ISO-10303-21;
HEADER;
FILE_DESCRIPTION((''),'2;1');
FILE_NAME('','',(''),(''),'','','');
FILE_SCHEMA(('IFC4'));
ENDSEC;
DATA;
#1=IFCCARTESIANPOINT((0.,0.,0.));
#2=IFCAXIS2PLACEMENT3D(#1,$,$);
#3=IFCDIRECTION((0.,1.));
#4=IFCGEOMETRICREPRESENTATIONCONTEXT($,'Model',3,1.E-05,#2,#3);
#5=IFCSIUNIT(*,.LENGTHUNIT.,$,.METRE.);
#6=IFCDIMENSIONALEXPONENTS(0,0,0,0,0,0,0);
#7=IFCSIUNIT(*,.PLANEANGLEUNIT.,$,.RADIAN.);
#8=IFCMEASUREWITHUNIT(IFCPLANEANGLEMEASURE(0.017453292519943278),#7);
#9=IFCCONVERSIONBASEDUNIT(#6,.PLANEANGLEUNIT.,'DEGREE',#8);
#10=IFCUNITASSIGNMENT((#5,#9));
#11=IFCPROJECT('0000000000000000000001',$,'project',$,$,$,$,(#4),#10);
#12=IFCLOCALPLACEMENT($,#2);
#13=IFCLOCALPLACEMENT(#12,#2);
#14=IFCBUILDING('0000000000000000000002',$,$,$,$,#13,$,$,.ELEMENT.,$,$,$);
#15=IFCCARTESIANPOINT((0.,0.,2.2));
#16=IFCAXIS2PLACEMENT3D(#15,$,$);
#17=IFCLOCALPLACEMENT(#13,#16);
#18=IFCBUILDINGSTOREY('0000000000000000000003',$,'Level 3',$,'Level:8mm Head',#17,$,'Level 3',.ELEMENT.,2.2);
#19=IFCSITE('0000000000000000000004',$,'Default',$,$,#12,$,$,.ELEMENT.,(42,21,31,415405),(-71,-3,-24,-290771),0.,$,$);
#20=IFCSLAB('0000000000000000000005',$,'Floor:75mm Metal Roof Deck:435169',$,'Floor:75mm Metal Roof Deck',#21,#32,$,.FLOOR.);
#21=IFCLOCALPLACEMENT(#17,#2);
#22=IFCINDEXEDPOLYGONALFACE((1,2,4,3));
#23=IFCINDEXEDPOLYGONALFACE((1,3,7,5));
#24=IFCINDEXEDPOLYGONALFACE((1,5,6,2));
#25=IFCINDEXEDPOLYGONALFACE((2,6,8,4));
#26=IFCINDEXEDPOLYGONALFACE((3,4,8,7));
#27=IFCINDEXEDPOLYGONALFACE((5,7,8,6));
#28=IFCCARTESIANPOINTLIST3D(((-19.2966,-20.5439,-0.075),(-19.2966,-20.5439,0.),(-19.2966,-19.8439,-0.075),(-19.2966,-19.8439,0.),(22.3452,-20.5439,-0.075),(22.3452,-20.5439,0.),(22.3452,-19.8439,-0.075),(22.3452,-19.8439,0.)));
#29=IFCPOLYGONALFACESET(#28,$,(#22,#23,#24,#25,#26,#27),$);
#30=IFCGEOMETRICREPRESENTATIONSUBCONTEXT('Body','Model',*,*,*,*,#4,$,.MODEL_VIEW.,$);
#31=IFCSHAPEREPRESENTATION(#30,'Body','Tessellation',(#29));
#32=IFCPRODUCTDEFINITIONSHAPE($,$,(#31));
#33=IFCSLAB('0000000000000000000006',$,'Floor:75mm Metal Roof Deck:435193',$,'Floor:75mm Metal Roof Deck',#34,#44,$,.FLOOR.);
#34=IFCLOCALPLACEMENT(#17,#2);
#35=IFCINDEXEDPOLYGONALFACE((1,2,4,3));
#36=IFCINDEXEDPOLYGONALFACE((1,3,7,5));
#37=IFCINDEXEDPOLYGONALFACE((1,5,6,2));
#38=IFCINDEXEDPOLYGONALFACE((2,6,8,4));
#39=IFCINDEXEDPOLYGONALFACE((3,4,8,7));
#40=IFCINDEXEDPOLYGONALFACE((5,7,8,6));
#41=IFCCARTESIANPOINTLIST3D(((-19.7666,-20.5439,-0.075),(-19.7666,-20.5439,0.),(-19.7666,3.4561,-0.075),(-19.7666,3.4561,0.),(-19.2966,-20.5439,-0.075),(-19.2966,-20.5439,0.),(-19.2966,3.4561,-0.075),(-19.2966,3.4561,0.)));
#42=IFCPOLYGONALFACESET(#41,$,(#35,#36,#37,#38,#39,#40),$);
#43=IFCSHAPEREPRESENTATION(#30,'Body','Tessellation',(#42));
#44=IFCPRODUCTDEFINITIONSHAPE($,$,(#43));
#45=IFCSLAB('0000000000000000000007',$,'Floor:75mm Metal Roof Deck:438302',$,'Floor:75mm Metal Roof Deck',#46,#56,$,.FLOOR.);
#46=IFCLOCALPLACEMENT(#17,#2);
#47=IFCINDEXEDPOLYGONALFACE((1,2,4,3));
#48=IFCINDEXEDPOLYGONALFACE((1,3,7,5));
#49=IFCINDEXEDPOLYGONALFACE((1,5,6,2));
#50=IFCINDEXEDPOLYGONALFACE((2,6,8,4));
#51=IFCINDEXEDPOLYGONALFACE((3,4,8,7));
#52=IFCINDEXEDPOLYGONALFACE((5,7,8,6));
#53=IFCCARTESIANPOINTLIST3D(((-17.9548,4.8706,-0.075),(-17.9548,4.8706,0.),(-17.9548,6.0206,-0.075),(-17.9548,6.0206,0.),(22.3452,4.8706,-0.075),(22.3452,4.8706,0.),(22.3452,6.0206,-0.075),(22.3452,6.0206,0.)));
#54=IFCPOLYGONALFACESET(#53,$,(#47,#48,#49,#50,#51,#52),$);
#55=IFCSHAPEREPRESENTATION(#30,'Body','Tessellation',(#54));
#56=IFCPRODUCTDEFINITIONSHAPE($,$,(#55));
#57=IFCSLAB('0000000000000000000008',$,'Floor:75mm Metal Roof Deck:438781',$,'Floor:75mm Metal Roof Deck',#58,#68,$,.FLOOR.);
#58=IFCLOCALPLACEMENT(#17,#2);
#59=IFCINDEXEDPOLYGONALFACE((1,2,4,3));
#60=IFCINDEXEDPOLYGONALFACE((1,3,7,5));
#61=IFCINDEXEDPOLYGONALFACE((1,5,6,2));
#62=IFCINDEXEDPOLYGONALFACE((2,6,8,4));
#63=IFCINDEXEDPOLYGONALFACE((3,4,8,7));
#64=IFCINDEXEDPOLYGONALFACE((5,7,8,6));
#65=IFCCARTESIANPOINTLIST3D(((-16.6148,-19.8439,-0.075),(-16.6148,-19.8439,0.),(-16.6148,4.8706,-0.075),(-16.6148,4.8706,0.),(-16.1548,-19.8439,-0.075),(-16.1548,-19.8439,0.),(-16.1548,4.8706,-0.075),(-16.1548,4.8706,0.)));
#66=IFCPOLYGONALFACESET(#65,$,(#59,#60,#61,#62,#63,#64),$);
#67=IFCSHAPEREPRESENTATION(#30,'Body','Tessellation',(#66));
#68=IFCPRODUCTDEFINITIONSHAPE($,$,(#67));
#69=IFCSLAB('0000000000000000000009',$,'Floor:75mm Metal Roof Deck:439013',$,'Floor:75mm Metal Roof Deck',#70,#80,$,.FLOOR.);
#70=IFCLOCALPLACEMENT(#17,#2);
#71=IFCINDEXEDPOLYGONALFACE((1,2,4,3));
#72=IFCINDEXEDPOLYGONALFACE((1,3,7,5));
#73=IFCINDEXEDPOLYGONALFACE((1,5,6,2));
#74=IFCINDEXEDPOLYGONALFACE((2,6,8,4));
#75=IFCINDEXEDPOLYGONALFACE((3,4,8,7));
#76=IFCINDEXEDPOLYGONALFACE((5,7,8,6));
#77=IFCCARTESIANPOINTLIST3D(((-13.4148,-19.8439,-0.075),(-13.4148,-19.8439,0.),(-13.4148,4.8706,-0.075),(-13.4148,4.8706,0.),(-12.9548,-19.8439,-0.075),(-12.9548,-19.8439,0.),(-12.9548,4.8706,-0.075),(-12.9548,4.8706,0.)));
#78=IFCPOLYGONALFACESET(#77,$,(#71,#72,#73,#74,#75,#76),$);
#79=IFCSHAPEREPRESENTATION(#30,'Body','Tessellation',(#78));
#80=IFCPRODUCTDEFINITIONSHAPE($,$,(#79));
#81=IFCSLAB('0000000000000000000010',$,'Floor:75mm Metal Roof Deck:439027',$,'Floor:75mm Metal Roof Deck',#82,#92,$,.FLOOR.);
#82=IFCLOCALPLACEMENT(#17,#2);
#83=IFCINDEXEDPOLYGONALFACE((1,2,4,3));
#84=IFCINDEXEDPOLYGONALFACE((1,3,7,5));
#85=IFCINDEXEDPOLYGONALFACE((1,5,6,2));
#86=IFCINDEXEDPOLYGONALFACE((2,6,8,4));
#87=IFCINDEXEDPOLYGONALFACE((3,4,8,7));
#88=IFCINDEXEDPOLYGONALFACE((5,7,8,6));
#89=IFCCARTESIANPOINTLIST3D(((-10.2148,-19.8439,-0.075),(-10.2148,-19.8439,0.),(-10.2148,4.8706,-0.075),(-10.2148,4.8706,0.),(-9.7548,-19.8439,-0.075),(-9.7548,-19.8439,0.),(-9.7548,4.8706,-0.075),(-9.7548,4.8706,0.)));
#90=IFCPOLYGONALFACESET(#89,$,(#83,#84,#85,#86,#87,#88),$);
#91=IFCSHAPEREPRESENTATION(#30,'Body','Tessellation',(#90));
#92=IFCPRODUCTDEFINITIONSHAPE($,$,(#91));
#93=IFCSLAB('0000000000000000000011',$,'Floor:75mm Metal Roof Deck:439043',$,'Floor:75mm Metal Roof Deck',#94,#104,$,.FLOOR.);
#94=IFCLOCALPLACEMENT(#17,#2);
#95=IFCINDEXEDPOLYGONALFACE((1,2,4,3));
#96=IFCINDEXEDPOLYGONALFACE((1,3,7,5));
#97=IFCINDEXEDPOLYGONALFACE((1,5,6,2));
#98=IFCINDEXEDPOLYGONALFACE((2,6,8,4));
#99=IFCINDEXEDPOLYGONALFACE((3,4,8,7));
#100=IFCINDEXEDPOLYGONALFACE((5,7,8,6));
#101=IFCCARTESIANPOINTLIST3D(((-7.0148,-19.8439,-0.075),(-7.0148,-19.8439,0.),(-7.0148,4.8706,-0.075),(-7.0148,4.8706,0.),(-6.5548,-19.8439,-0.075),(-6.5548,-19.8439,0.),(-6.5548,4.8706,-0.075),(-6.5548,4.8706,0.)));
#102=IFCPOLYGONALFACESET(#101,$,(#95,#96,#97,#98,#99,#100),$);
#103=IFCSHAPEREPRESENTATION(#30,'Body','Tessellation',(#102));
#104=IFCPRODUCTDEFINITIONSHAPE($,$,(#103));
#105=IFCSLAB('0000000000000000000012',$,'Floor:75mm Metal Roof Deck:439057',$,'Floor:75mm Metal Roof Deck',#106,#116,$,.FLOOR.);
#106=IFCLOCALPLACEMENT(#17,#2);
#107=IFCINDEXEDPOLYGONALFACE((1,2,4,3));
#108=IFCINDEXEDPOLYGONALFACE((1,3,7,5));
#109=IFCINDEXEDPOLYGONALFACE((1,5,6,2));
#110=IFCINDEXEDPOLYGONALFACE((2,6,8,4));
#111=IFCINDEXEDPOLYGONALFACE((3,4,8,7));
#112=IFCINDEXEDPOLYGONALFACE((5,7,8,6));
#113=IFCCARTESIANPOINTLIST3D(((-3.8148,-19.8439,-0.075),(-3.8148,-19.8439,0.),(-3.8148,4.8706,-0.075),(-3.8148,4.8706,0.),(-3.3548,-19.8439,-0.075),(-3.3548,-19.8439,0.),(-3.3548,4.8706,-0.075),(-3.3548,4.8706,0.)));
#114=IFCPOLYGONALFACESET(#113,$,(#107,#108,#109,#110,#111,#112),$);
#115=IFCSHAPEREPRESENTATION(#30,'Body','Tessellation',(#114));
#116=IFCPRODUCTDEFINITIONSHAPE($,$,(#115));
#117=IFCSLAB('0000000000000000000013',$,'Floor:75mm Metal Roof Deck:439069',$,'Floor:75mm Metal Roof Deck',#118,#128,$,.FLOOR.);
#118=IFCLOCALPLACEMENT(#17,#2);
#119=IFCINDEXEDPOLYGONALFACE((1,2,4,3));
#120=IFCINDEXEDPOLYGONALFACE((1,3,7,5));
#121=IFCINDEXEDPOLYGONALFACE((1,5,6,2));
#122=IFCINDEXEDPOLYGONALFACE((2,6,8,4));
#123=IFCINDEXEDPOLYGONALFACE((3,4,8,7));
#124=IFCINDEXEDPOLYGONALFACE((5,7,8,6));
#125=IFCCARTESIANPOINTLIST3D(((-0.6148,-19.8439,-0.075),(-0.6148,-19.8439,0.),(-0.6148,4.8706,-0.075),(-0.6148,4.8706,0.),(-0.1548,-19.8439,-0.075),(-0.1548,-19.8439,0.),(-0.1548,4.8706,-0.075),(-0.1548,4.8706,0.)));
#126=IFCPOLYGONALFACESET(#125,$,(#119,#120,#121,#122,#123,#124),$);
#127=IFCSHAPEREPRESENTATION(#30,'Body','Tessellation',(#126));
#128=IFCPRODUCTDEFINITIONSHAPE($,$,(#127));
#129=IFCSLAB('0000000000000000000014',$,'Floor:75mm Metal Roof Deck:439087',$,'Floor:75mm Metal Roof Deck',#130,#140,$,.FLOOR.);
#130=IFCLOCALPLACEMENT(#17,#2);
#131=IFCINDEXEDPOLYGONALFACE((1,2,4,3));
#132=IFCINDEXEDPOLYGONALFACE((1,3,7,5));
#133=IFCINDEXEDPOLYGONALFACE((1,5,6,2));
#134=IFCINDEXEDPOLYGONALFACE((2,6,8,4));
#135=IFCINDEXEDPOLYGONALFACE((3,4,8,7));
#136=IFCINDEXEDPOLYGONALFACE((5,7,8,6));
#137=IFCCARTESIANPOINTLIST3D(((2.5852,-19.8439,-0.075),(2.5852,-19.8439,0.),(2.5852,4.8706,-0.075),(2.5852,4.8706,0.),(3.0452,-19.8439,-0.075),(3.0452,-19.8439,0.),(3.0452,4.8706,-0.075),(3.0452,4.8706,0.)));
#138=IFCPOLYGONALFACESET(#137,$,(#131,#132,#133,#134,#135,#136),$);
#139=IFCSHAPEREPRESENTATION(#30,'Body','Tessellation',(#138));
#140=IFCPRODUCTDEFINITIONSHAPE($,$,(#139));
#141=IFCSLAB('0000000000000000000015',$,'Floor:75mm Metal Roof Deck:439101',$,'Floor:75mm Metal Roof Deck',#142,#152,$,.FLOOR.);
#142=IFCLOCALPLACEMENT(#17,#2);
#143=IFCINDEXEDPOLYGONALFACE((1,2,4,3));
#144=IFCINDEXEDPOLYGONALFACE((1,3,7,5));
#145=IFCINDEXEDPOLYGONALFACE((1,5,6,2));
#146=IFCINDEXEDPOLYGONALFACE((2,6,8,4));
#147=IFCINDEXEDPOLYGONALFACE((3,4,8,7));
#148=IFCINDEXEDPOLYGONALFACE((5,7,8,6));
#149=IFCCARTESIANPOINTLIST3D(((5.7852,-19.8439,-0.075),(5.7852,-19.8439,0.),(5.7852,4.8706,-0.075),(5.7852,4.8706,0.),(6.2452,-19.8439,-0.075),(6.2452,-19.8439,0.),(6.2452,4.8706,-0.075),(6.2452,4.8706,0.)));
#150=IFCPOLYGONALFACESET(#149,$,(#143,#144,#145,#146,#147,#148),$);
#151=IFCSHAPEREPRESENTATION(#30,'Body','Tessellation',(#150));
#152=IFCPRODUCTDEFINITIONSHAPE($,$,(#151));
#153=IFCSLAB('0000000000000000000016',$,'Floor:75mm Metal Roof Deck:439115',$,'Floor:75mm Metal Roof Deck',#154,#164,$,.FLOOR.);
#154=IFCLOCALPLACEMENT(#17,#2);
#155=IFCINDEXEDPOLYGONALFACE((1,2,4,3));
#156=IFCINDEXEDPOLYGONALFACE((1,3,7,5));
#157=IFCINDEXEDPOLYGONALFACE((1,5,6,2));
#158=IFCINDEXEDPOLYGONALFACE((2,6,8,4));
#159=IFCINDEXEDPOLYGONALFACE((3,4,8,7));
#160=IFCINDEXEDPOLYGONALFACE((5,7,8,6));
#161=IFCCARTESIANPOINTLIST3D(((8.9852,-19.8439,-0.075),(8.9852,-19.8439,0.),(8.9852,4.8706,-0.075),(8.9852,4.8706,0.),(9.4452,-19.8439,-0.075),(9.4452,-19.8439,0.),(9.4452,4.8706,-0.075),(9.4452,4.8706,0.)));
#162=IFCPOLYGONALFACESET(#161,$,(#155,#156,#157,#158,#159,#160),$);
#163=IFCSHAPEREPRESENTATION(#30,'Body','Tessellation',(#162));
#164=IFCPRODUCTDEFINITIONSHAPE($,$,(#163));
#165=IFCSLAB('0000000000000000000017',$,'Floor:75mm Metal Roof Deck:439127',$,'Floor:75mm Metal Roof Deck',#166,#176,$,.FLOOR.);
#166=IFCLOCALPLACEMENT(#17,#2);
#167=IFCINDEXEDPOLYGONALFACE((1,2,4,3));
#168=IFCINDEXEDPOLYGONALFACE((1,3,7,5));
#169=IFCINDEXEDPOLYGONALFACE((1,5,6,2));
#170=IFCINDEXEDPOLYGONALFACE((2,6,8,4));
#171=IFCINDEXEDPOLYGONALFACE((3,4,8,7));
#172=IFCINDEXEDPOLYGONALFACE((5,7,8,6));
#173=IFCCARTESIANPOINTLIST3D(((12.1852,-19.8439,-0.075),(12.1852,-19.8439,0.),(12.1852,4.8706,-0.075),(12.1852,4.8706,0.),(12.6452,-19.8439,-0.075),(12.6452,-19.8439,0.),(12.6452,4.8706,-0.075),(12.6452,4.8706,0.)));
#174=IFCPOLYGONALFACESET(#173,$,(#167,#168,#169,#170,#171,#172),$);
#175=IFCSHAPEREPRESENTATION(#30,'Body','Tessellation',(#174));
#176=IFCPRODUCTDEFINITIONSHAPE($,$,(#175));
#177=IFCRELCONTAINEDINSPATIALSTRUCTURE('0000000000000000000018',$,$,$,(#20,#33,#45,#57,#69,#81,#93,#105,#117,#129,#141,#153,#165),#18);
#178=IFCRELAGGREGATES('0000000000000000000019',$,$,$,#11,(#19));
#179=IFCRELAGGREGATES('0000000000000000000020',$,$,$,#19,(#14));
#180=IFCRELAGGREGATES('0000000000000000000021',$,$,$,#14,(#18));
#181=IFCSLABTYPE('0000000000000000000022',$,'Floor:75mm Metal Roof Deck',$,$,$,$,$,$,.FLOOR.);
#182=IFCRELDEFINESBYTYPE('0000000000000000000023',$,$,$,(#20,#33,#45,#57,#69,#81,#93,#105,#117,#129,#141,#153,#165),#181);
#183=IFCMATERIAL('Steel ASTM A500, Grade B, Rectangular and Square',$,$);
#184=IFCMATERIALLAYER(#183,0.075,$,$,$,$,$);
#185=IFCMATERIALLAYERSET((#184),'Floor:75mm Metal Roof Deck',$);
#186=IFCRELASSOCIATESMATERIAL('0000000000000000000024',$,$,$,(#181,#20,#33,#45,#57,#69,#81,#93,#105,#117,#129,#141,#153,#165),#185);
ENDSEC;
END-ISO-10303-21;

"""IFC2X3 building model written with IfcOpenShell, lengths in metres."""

from ifc_helpers import new_model, entity, si_unit, converted_unit, direction, frame, frame_2d, origin, place, context, subcontext, project, spatial, rectangle, extrude, material, layer, layer_set, layer_usage, type_object, element, save


model = new_model("IFC2X3")

# Units and contexts
model_context = context("Model", 3, precision=1e-05, world=origin(), true_north=direction((0.0, 1.0)))
body_context = subcontext(model_context, "Body", "Model", "MODEL_VIEW")
ifc_project = project(units=[si_unit("LENGTHUNIT", "METRE"), converted_unit("PLANEANGLEUNIT", "DEGREE", entity("IfcPlaneAngleMeasure", 0.017453292519943278), si_unit("PLANEANGLEUNIT", "RADIAN"), dimensions=[0, 0, 0, 0, 0, 0, 0])], contexts=[model_context])

# Site, building, storey
site_placement = place(None, origin())
site = spatial("IfcSite", under=ifc_project, at=site_placement, Name="Default", CompositionType="ELEMENT", RefLatitude=(42, 21, 31, 415405), RefLongitude=(-71, -3, -24, -290771), RefElevation=0.0)
building_placement = place(site_placement, origin())
building = spatial("IfcBuilding", under=site, at=building_placement, CompositionType="ELEMENT")
storey_placement = place(building_placement, frame((0.0, 0.0, 2.2)))
storey = spatial("IfcBuildingStorey", under=building, at=storey_placement, Name="Level 3", ObjectType="Level:8mm Head", LongName="Level 3", CompositionType="ELEMENT", Elevation=2.2)

# Slabs
ifc_material = material(Name="Steel ASTM A500, Grade B, Rectangular and Square")
ifc_layer = layer(ifc_material, 0.075)
ifc_layer_set = layer_set([ifc_layer], Name="Floor:75mm Metal Roof Deck")
ifc_layer_usage_1 = layer_usage(ifc_layer_set, "AXIS3", "POSITIVE", 0.0)
slab_type = type_object("IfcSlabType", Name="Floor:75mm Metal Roof Deck", PredefinedType="FLOOR", material=ifc_layer_set)
slab_1_placement = place(storey_placement, origin())
element("IfcSlab", 1, at=slab_1_placement, inside=storey, type_object=slab_type, material=ifc_layer_usage_1, Name="Floor:75mm Metal Roof Deck:435169", ObjectType="Floor:75mm Metal Roof Deck", PredefinedType="FLOOR", context=body_context, shape_type="SweptSolid", body=[
    extrude(rectangle(XDim=0.7, YDim=41.6417, at=frame_2d((0.0, 0.0), x_axis=(1.0, 0.0))), frame((1.5243, -20.1939, 0.0), z_axis=(0.0, 0.0, -1.0), x_axis=(0.0, 1.0, 0.0)), (0.0, 0.0, 1.0), 0.075),
])
ifc_layer_usage_2 = layer_usage(ifc_layer_set, "AXIS3", "POSITIVE", 0.0)
slab_2_placement = place(storey_placement, origin())
element("IfcSlab", 2, at=slab_2_placement, inside=storey, type_object=slab_type, material=ifc_layer_usage_2, Name="Floor:75mm Metal Roof Deck:435193", ObjectType="Floor:75mm Metal Roof Deck", PredefinedType="FLOOR", context=body_context, shape_type="SweptSolid", body=[
    extrude(rectangle(XDim=24.0, YDim=0.47, at=frame_2d((0.0, 0.0), x_axis=(1.0, 0.0))), frame((-19.5316, -8.5439, 0.0), z_axis=(0.0, 0.0, -1.0), x_axis=(0.0, 1.0, 0.0)), (0.0, 0.0, 1.0), 0.075),
])
ifc_layer_usage_3 = layer_usage(ifc_layer_set, "AXIS3", "POSITIVE", 0.0)
slab_3_placement = place(storey_placement, origin())
element("IfcSlab", 3, at=slab_3_placement, inside=storey, type_object=slab_type, material=ifc_layer_usage_3, Name="Floor:75mm Metal Roof Deck:438302", ObjectType="Floor:75mm Metal Roof Deck", PredefinedType="FLOOR", context=body_context, shape_type="SweptSolid", body=[
    extrude(rectangle(XDim=1.15, YDim=40.3, at=frame_2d((0.0, 0.0), x_axis=(1.0, 0.0))), frame((2.1952, 5.4456, 0.0), z_axis=(0.0, 0.0, -1.0), x_axis=(0.0, 1.0, 0.0)), (0.0, 0.0, 1.0), 0.075),
])
ifc_layer_usage_4 = layer_usage(ifc_layer_set, "AXIS3", "POSITIVE", 0.0)
slab_4_placement = place(storey_placement, origin())
element("IfcSlab", 4, at=slab_4_placement, inside=storey, type_object=slab_type, material=ifc_layer_usage_4, Name="Floor:75mm Metal Roof Deck:438781", ObjectType="Floor:75mm Metal Roof Deck", PredefinedType="FLOOR", context=body_context, shape_type="SweptSolid", body=[
    extrude(rectangle(XDim=24.7144, YDim=0.46, at=frame_2d((0.0, 0.0), x_axis=(1.0, 0.0))), frame((-16.3848, -7.4867, 0.0), z_axis=(0.0, 0.0, -1.0), x_axis=(0.0, 1.0, 0.0)), (0.0, 0.0, 1.0), 0.075),
])
ifc_layer_usage_5 = layer_usage(ifc_layer_set, "AXIS3", "POSITIVE", 0.0)
slab_5_placement = place(storey_placement, origin())
element("IfcSlab", 5, at=slab_5_placement, inside=storey, type_object=slab_type, material=ifc_layer_usage_5, Name="Floor:75mm Metal Roof Deck:439013", ObjectType="Floor:75mm Metal Roof Deck", PredefinedType="FLOOR", context=body_context, shape_type="SweptSolid", body=[
    extrude(rectangle(XDim=24.7144, YDim=0.46, at=frame_2d((0.0, 0.0), x_axis=(1.0, 0.0))), frame((-13.1848, -7.4867, 0.0), z_axis=(0.0, 0.0, -1.0), x_axis=(0.0, 1.0, 0.0)), (0.0, 0.0, 1.0), 0.075),
])
ifc_layer_usage_6 = layer_usage(ifc_layer_set, "AXIS3", "POSITIVE", 0.0)
slab_6_placement = place(storey_placement, origin())
element("IfcSlab", 6, at=slab_6_placement, inside=storey, type_object=slab_type, material=ifc_layer_usage_6, Name="Floor:75mm Metal Roof Deck:439027", ObjectType="Floor:75mm Metal Roof Deck", PredefinedType="FLOOR", context=body_context, shape_type="SweptSolid", body=[
    extrude(rectangle(XDim=24.7144, YDim=0.46, at=frame_2d((0.0, 0.0), x_axis=(1.0, 0.0))), frame((-9.9848, -7.4867, 0.0), z_axis=(0.0, 0.0, -1.0), x_axis=(0.0, 1.0, 0.0)), (0.0, 0.0, 1.0), 0.075),
])
ifc_layer_usage_7 = layer_usage(ifc_layer_set, "AXIS3", "POSITIVE", 0.0)
slab_7_placement = place(storey_placement, origin())
element("IfcSlab", 7, at=slab_7_placement, inside=storey, type_object=slab_type, material=ifc_layer_usage_7, Name="Floor:75mm Metal Roof Deck:439043", ObjectType="Floor:75mm Metal Roof Deck", PredefinedType="FLOOR", context=body_context, shape_type="SweptSolid", body=[
    extrude(rectangle(XDim=24.7144, YDim=0.46, at=frame_2d((0.0, 0.0), x_axis=(1.0, 0.0))), frame((-6.7848, -7.4867, 0.0), z_axis=(0.0, 0.0, -1.0), x_axis=(0.0, 1.0, 0.0)), (0.0, 0.0, 1.0), 0.075),
])
ifc_layer_usage_8 = layer_usage(ifc_layer_set, "AXIS3", "POSITIVE", 0.0)
slab_8_placement = place(storey_placement, origin())
element("IfcSlab", 8, at=slab_8_placement, inside=storey, type_object=slab_type, material=ifc_layer_usage_8, Name="Floor:75mm Metal Roof Deck:439057", ObjectType="Floor:75mm Metal Roof Deck", PredefinedType="FLOOR", context=body_context, shape_type="SweptSolid", body=[
    extrude(rectangle(XDim=24.7144, YDim=0.46, at=frame_2d((0.0, 0.0), x_axis=(1.0, 0.0))), frame((-3.5848, -7.4867, 0.0), z_axis=(0.0, 0.0, -1.0), x_axis=(0.0, 1.0, 0.0)), (0.0, 0.0, 1.0), 0.075),
])
ifc_layer_usage_9 = layer_usage(ifc_layer_set, "AXIS3", "POSITIVE", 0.0)
slab_9_placement = place(storey_placement, origin())
element("IfcSlab", 9, at=slab_9_placement, inside=storey, type_object=slab_type, material=ifc_layer_usage_9, Name="Floor:75mm Metal Roof Deck:439069", ObjectType="Floor:75mm Metal Roof Deck", PredefinedType="FLOOR", context=body_context, shape_type="SweptSolid", body=[
    extrude(rectangle(XDim=24.7144, YDim=0.46, at=frame_2d((0.0, 0.0), x_axis=(1.0, 0.0))), frame((-0.3848, -7.4867, 0.0), z_axis=(0.0, 0.0, -1.0), x_axis=(0.0, 1.0, 0.0)), (0.0, 0.0, 1.0), 0.075),
])
ifc_layer_usage_10 = layer_usage(ifc_layer_set, "AXIS3", "POSITIVE", 0.0)
slab_10_placement = place(storey_placement, origin())
element("IfcSlab", 10, at=slab_10_placement, inside=storey, type_object=slab_type, material=ifc_layer_usage_10, Name="Floor:75mm Metal Roof Deck:439087", ObjectType="Floor:75mm Metal Roof Deck", PredefinedType="FLOOR", context=body_context, shape_type="SweptSolid", body=[
    extrude(rectangle(XDim=24.7144, YDim=0.46, at=frame_2d((0.0, 0.0), x_axis=(1.0, 0.0))), frame((2.8152, -7.4867, 0.0), z_axis=(0.0, 0.0, -1.0), x_axis=(0.0, 1.0, 0.0)), (0.0, 0.0, 1.0), 0.075),
])
ifc_layer_usage_11 = layer_usage(ifc_layer_set, "AXIS3", "POSITIVE", 0.0)
slab_11_placement = place(storey_placement, origin())
element("IfcSlab", 11, at=slab_11_placement, inside=storey, type_object=slab_type, material=ifc_layer_usage_11, Name="Floor:75mm Metal Roof Deck:439101", ObjectType="Floor:75mm Metal Roof Deck", PredefinedType="FLOOR", context=body_context, shape_type="SweptSolid", body=[
    extrude(rectangle(XDim=24.7144, YDim=0.46, at=frame_2d((0.0, 0.0), x_axis=(1.0, 0.0))), frame((6.0152, -7.4867, 0.0), z_axis=(0.0, 0.0, -1.0), x_axis=(0.0, 1.0, 0.0)), (0.0, 0.0, 1.0), 0.075),
])
ifc_layer_usage_12 = layer_usage(ifc_layer_set, "AXIS3", "POSITIVE", 0.0)
slab_12_placement = place(storey_placement, origin())
element("IfcSlab", 12, at=slab_12_placement, inside=storey, type_object=slab_type, material=ifc_layer_usage_12, Name="Floor:75mm Metal Roof Deck:439115", ObjectType="Floor:75mm Metal Roof Deck", PredefinedType="FLOOR", context=body_context, shape_type="SweptSolid", body=[
    extrude(rectangle(XDim=24.7144, YDim=0.46, at=frame_2d((0.0, 0.0), x_axis=(1.0, 0.0))), frame((9.2152, -7.4867, 0.0), z_axis=(0.0, 0.0, -1.0), x_axis=(0.0, 1.0, 0.0)), (0.0, 0.0, 1.0), 0.075),
])
ifc_layer_usage_13 = layer_usage(ifc_layer_set, "AXIS3", "POSITIVE", 0.0)
slab_13_placement = place(storey_placement, origin())
element("IfcSlab", 13, at=slab_13_placement, inside=storey, type_object=slab_type, material=ifc_layer_usage_13, Name="Floor:75mm Metal Roof Deck:439127", ObjectType="Floor:75mm Metal Roof Deck", PredefinedType="FLOOR", context=body_context, shape_type="SweptSolid", body=[
    extrude(rectangle(XDim=24.7144, YDim=0.46, at=frame_2d((0.0, 0.0), x_axis=(1.0, 0.0))), frame((12.4152, -7.4867, 0.0), z_axis=(0.0, 0.0, -1.0), x_axis=(0.0, 1.0, 0.0)), (0.0, 0.0, 1.0), 0.075),
])

save(model, "model.ifc")
